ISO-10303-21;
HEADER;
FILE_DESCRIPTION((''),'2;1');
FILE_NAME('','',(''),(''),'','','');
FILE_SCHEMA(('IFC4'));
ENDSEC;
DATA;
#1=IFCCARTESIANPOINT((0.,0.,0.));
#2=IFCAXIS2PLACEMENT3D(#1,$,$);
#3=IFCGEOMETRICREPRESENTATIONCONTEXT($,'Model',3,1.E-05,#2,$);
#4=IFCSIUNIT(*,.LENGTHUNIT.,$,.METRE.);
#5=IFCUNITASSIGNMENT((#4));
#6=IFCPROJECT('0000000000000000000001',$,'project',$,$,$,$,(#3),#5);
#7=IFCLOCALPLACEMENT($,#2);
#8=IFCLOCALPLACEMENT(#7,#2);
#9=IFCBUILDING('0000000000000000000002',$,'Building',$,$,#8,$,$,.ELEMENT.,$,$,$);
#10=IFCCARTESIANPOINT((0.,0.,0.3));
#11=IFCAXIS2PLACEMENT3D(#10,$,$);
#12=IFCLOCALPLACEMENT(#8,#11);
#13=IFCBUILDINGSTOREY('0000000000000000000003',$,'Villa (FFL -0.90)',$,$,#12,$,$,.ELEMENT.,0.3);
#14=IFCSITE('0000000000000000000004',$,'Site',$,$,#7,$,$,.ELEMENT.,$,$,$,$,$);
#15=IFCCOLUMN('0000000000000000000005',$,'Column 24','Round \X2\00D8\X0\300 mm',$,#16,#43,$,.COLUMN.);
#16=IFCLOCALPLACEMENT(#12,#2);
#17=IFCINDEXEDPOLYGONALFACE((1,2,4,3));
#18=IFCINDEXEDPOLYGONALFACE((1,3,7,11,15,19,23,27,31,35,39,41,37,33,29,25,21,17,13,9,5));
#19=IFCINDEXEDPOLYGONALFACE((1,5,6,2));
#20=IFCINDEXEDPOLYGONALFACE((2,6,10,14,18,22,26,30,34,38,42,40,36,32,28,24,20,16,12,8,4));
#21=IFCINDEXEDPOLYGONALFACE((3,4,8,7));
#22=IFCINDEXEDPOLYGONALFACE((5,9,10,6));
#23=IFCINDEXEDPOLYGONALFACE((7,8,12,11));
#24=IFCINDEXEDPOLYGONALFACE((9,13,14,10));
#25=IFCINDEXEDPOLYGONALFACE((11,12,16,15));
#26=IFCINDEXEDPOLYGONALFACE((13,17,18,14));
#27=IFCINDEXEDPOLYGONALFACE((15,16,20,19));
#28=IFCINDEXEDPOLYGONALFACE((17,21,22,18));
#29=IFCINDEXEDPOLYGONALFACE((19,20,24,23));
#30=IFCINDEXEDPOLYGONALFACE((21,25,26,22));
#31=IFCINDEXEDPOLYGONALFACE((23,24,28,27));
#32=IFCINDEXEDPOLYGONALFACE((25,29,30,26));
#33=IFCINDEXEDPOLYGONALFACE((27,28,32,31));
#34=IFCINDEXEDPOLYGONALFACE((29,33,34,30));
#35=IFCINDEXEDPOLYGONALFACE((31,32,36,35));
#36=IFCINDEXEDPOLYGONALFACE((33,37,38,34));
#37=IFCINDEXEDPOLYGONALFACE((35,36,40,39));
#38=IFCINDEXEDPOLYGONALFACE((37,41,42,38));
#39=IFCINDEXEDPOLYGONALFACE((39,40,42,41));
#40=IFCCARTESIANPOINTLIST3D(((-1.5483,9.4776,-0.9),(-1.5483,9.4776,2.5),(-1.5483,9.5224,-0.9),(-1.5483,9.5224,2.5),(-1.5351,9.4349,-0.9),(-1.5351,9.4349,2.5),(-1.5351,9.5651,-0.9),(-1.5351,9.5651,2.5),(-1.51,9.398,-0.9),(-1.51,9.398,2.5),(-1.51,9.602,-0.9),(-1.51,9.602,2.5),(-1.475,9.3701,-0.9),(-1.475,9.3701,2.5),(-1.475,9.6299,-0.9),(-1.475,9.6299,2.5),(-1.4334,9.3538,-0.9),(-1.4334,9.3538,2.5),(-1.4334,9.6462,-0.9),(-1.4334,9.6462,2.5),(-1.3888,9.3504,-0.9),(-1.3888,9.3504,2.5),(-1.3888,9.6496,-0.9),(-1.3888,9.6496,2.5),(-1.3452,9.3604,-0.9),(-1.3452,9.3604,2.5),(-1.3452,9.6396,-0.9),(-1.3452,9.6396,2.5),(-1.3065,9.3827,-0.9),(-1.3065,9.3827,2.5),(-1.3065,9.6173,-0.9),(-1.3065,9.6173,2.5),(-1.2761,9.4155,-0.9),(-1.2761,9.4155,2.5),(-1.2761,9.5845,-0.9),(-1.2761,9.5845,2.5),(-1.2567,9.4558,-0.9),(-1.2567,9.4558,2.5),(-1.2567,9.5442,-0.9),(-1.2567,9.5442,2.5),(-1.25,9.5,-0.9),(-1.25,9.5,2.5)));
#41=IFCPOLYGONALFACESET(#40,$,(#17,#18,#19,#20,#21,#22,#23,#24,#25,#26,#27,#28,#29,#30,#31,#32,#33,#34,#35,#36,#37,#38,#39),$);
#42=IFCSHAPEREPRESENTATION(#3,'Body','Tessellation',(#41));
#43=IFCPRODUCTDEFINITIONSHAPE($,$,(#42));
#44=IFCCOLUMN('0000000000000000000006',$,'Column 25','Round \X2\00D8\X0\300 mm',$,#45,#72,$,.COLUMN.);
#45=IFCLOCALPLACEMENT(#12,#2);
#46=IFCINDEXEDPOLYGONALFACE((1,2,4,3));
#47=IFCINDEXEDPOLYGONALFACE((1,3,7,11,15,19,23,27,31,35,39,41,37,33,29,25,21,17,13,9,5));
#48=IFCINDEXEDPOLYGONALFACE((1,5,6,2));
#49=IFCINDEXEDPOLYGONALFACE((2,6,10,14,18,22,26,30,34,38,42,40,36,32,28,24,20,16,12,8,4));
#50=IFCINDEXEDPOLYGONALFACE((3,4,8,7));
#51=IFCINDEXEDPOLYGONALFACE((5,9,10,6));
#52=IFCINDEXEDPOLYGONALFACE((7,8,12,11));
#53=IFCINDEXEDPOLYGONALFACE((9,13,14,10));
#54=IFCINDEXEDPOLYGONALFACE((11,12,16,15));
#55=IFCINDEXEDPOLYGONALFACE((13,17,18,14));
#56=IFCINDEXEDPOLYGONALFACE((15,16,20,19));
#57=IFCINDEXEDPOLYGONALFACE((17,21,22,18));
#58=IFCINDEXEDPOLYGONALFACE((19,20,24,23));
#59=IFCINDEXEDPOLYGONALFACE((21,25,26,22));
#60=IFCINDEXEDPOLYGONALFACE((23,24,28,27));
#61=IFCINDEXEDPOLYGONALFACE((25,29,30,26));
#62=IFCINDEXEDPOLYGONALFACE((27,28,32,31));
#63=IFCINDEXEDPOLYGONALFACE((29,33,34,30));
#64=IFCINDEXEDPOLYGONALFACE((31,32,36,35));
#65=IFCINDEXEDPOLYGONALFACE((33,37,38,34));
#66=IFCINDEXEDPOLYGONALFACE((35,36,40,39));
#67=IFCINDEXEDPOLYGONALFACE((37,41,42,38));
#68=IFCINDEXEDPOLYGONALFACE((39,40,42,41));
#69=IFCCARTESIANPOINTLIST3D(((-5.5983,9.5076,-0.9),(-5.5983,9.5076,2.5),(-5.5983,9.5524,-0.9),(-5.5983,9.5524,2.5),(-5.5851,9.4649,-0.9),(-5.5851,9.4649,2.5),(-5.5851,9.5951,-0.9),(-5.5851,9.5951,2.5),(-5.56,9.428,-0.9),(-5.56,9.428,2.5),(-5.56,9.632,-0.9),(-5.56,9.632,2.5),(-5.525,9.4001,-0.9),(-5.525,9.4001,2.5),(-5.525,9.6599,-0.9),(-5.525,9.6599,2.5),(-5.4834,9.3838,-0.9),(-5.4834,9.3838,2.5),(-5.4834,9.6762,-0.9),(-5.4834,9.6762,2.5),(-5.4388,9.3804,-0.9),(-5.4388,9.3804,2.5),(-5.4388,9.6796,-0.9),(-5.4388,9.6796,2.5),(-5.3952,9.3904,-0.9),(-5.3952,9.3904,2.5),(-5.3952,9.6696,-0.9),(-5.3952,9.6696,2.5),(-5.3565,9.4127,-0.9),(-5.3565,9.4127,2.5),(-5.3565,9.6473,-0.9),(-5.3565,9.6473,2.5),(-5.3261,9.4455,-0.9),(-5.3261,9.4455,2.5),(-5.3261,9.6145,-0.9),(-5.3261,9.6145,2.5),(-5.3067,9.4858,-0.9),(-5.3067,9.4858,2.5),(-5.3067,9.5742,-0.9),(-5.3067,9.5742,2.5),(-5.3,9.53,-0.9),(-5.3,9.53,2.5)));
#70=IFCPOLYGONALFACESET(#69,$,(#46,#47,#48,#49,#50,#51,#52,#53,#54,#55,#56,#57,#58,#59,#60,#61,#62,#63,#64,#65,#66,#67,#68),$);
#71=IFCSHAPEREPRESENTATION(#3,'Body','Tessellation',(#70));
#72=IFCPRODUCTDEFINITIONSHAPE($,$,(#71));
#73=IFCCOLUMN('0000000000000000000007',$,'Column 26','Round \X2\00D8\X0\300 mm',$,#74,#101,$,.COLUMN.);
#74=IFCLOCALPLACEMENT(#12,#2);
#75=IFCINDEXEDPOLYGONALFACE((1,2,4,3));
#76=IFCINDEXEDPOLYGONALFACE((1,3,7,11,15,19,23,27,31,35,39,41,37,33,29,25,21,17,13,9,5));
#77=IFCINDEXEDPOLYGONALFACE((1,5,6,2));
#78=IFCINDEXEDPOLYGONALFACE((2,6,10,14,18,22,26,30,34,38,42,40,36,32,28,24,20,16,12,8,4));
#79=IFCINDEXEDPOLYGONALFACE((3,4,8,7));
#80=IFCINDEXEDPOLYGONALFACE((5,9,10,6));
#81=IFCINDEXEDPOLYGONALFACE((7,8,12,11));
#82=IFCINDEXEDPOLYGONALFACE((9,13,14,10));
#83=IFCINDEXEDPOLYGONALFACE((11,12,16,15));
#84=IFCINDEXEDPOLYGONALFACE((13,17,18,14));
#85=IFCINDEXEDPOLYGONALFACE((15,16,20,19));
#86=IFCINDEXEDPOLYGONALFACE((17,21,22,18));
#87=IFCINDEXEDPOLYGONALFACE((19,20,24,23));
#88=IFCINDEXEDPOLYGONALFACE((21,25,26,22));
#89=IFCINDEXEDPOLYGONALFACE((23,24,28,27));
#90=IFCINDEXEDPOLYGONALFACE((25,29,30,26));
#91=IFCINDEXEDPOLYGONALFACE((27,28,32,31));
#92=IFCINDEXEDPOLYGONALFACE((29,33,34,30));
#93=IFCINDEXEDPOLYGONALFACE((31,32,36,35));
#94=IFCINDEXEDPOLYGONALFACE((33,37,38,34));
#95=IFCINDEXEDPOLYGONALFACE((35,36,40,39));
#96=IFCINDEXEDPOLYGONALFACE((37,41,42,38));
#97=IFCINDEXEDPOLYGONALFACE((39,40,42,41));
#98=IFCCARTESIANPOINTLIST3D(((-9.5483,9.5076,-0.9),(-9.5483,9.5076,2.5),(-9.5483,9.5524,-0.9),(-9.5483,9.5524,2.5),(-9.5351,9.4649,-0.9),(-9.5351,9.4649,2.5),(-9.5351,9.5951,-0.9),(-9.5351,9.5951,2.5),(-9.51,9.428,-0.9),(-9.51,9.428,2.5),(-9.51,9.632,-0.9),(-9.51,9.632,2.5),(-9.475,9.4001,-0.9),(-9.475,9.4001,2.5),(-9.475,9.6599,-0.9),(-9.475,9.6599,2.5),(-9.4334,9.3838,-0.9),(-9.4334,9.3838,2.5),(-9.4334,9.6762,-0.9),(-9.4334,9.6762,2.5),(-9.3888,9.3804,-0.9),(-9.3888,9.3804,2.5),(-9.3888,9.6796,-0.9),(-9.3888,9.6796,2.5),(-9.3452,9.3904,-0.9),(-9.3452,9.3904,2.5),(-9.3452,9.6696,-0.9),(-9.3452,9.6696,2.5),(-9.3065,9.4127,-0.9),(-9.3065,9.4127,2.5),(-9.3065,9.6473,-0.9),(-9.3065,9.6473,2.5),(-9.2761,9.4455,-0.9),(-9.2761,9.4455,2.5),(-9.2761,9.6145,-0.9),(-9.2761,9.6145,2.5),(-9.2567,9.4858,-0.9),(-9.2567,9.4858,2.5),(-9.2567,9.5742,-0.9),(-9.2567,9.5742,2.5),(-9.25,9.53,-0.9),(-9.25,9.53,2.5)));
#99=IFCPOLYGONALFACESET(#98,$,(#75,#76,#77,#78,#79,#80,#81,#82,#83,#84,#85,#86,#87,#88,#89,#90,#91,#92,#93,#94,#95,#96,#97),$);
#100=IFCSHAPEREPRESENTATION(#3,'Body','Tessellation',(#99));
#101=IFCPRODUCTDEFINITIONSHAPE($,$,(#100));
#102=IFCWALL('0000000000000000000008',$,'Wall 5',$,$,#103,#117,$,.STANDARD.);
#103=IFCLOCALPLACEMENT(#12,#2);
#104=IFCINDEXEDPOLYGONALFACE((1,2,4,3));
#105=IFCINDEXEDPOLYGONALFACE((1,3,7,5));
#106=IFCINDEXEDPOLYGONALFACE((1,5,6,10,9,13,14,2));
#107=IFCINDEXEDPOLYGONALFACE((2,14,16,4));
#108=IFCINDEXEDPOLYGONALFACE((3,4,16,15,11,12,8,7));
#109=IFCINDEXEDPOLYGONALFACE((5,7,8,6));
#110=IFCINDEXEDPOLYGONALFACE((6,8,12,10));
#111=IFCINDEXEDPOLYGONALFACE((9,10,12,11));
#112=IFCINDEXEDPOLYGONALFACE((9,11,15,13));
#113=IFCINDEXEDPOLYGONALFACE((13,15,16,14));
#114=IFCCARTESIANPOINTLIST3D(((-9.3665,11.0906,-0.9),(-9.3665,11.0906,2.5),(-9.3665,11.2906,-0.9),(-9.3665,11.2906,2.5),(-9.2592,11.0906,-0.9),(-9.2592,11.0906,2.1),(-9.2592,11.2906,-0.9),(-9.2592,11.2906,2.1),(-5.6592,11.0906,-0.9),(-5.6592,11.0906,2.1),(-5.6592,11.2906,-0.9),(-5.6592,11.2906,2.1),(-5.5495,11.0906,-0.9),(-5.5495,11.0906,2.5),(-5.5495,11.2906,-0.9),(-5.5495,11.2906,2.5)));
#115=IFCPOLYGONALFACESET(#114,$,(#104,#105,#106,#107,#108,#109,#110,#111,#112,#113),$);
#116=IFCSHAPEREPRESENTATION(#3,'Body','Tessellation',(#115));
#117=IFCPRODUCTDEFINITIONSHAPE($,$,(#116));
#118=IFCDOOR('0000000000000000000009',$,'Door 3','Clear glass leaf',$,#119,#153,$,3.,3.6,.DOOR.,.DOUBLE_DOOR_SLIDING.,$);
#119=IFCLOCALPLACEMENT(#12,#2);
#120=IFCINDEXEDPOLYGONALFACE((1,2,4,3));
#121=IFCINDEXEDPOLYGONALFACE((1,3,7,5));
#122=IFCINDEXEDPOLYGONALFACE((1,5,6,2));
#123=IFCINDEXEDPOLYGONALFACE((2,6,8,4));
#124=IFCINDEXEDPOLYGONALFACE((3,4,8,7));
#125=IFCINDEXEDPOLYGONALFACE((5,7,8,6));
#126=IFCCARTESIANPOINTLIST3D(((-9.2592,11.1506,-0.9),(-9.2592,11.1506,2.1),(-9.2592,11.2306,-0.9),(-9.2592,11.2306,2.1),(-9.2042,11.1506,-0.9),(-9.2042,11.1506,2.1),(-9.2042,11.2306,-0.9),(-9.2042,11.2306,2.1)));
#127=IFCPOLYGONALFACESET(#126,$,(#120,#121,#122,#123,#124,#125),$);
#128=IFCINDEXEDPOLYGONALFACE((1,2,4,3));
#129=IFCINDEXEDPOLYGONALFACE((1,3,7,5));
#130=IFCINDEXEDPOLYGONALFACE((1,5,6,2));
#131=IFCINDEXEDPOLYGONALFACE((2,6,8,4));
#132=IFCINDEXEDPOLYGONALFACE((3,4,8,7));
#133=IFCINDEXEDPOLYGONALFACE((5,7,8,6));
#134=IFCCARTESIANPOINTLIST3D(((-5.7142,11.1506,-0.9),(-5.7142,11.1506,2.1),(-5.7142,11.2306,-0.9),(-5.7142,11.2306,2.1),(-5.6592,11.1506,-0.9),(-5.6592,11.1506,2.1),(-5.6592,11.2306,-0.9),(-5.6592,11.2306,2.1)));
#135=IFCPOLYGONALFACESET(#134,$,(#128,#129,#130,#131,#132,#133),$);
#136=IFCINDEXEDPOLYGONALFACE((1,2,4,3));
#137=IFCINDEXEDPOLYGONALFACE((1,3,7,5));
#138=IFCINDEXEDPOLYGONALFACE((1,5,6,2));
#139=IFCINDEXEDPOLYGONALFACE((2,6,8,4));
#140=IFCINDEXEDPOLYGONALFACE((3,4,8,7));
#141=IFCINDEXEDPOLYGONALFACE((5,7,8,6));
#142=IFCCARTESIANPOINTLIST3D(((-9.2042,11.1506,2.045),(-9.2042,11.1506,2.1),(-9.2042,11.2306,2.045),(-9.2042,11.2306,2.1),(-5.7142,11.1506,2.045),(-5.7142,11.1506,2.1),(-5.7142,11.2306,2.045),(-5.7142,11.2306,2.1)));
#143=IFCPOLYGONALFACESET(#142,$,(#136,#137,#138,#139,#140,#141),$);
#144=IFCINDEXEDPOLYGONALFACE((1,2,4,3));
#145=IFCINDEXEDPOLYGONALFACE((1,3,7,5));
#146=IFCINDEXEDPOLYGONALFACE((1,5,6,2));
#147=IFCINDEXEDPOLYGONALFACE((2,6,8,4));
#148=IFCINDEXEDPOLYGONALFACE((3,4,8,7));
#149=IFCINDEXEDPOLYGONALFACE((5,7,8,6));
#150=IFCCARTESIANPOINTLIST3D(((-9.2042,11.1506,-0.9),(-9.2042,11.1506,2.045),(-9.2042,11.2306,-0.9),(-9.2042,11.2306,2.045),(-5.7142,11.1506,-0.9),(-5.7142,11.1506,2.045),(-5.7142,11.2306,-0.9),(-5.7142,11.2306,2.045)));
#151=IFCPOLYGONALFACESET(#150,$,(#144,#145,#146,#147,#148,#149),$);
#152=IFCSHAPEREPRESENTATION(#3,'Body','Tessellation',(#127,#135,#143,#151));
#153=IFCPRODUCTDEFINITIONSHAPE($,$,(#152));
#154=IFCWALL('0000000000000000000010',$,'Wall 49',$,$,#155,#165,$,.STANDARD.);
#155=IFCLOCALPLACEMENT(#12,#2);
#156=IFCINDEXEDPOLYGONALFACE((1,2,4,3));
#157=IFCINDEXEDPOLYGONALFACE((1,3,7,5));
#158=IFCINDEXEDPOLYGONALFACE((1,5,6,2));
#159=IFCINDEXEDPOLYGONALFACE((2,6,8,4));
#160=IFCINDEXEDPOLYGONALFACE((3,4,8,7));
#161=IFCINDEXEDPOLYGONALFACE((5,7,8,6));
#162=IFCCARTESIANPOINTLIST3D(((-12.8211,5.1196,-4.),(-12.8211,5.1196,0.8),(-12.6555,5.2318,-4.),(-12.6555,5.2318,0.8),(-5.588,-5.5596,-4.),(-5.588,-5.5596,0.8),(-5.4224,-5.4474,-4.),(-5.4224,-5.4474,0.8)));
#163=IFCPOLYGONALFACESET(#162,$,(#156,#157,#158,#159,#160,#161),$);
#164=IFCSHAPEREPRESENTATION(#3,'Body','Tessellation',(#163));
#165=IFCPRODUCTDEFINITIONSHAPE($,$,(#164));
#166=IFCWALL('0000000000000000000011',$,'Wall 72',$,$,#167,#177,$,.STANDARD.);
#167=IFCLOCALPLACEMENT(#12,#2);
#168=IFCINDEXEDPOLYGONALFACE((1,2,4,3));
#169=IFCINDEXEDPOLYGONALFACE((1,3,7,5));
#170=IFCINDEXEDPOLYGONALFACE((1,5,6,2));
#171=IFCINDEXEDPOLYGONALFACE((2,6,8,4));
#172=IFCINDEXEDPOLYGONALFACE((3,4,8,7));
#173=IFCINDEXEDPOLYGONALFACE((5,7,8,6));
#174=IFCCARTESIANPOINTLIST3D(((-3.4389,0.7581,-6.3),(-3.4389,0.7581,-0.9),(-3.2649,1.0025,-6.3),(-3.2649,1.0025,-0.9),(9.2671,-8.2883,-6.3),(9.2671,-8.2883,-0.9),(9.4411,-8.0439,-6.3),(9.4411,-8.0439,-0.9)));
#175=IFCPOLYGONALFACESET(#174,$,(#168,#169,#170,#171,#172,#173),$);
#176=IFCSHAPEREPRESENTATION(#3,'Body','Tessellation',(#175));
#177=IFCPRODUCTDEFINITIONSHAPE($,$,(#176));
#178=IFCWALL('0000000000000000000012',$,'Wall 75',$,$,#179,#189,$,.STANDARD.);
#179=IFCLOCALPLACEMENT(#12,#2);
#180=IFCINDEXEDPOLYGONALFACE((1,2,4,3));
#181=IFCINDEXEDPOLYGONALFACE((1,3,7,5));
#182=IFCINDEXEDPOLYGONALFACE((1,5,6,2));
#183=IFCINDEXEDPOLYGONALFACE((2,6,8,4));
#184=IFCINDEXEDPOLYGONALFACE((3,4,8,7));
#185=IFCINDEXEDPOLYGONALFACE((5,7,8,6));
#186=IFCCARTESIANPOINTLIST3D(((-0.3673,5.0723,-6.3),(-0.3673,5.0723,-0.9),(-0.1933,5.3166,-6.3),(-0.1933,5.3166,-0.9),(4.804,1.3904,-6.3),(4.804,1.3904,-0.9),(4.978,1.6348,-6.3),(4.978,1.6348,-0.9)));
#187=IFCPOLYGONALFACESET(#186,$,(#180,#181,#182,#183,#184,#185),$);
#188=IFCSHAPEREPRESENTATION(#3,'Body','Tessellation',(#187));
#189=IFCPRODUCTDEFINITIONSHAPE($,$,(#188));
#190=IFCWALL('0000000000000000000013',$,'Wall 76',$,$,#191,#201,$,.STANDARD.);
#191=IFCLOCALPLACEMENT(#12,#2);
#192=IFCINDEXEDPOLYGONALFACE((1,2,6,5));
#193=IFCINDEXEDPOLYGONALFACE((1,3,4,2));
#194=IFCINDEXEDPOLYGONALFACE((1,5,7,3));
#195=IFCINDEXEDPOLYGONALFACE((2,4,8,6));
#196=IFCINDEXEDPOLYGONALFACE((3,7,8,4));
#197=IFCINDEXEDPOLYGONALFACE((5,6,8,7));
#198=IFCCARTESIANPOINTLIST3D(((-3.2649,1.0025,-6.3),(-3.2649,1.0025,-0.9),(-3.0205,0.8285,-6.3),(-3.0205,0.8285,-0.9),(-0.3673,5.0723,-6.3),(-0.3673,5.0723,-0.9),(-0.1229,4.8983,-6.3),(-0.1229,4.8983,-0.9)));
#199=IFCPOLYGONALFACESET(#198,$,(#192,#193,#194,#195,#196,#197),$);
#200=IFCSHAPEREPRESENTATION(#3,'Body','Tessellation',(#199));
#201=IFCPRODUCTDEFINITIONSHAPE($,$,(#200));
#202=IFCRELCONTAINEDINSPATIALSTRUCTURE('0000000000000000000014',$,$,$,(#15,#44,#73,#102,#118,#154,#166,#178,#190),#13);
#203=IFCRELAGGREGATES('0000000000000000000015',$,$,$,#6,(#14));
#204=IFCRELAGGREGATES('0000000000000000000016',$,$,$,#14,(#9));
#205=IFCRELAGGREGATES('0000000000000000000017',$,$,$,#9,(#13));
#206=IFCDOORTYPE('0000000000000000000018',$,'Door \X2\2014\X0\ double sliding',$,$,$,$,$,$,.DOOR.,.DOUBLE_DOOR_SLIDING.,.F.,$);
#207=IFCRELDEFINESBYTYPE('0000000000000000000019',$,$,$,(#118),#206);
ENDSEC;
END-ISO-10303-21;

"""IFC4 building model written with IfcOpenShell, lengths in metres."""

from ifc_helpers import new_model, si_unit, frame, frame_2d, origin, origin_2d, place, context, project, spatial, rectangle, circle, extrude, type_object, element, fill, save


model = new_model("IFC4")

# Units and contexts
model_context = context("Model", 3, precision=1e-05, world=origin())
ifc_project = project(units=[si_unit("LENGTHUNIT", "METRE")], contexts=[model_context])

# Site, building, storey
site_placement = place(None, origin())
site = spatial("IfcSite", under=ifc_project, at=site_placement, Name="Site", CompositionType="ELEMENT")
building_placement = place(site_placement, origin())
building = spatial("IfcBuilding", under=site, at=building_placement, Name="Building", CompositionType="ELEMENT")
storey_placement = place(building_placement, frame((0.0, 0.0, 0.3)))
storey = spatial("IfcBuildingStorey", under=building, at=storey_placement, Name="Villa (FFL -0.90)", CompositionType="ELEMENT", Elevation=0.3)

# Columns
for number, where, z_axis, x_axis, name in (
    (1, (-1.4, 9.5, -0.9), (0.0, 0.0, 1.0), (1.0, 0.0, 0.0), "Column 24"),
    (2, (-5.45, 9.53, -0.9), (0.0, 0.0, 1.0), (1.0, 0.0, 0.0), "Column 25"),
    (3, (-9.4, 9.53, -0.9), (0.0, 0.0, 1.0), (1.0, 0.0, 0.0), "Column 26"),
):
    element("IfcColumn", number, at=place(storey_placement, frame(where, z_axis=z_axis, x_axis=x_axis)), inside=storey, Name=name, Description="Round Ø300 mm", PredefinedType="COLUMN", context=model_context, shape_type="SweptSolid", body=[
        extrude(circle(Radius=0.15, at=origin_2d()), origin(), (0.0, 0.0, 1.0), 3.4),
    ])

# Wall, opening, door
wall_1_placement = place(storey_placement, frame((-9.3665, 11.1906, -0.9), z_axis=(0.0, 0.0, 1.0), x_axis=(1.0, 0.0, 0.0)))
wall_1 = element("IfcWall", 4, at=wall_1_placement, inside=storey, Name="Wall 5", PredefinedType="STANDARD", context=model_context, shape_type="SweptSolid", body=[
    extrude(rectangle(XDim=3.817, YDim=0.2, at=frame_2d((1.9085, 0.0))), origin(), (0.0, 0.0, 1.0), 3.4),
])
opening_placement = place(storey_placement, frame((-9.2592, 11.1906, -0.9), z_axis=(0.0, 0.0, 1.0), x_axis=(1.0, 0.0, 0.0)))
opening = element("IfcOpeningElement", 5, at=opening_placement, cuts=wall_1, PredefinedType="OPENING", context=model_context, shape_type="SweptSolid", body=[
    extrude(rectangle(XDim=3.6, YDim=0.26, at=frame_2d((1.8, 0.0))), origin(), (0.0, 0.0, 1.0), 3.0),
])
door_type = type_object("IfcDoorType", Name="Door — double sliding", OperationType="DOUBLE_DOOR_SLIDING", ParameterTakesPrecedence=False, PredefinedType="DOOR")
door_placement = place(storey_placement, frame((-9.2592, 11.1906, -0.9), z_axis=(0.0, 0.0, 1.0), x_axis=(1.0, 0.0, 0.0)))
door = element("IfcDoor", 6, at=door_placement, inside=storey, type_object=door_type, Name="Door 3", Description="Clear glass leaf", OperationType="DOUBLE_DOOR_SLIDING", OverallHeight=3.0, OverallWidth=3.6, PredefinedType="DOOR", context=model_context, shape_type="SweptSolid", body=[
    extrude(rectangle(XDim=0.055, YDim=0.08, at=frame_2d((0.0275, 0.0))), origin(), (0.0, 0.0, 1.0), 3.0),
    extrude(rectangle(XDim=0.055, YDim=0.08, at=frame_2d((3.5725, 0.0))), origin(), (0.0, 0.0, 1.0), 3.0),
    extrude(rectangle(XDim=3.49, YDim=0.08, at=frame_2d((1.8, 0.0))), frame((0.0, 0.0, 2.945)), (0.0, 0.0, 1.0), 0.055),
    extrude(rectangle(XDim=3.49, YDim=0.08, at=frame_2d((1.8, 0.0))), origin(), (0.0, 0.0, 1.0), 2.945),
])
fill(opening, door)

# Walls
wall_2_placement = place(storey_placement, frame((-12.7383, 5.1757, -4.0), z_axis=(0.0, 0.0, 1.0), x_axis=(0.560785, -0.827962, 0.0)))
element("IfcWall", 7, at=wall_2_placement, inside=storey, Name="Wall 49", PredefinedType="STANDARD", context=model_context, shape_type="SweptSolid", body=[
    extrude(rectangle(XDim=12.8982, YDim=0.2, at=frame_2d((6.4491, 0.0))), origin(), (0.0, 0.0, 1.0), 4.8),
])
wall_3_placement = place(storey_placement, frame((-3.3519, 0.8803, -6.3), z_axis=(0.0, 0.0, 1.0), x_axis=(0.814622, -0.579992, 0.0)))
element("IfcWall", 8, at=wall_3_placement, inside=storey, Name="Wall 72", PredefinedType="STANDARD", context=model_context, shape_type="SweptSolid", body=[
    extrude(rectangle(XDim=15.5974, YDim=0.3, at=frame_2d((7.7987, 0.0))), origin(), (0.0, 0.0, 1.0), 5.4),
])
wall_4_placement = place(storey_placement, frame((-0.2803, 5.1945, -6.3), z_axis=(0.0, 0.0, 1.0), x_axis=(0.814622, -0.579992, 0.0)))
element("IfcWall", 9, at=wall_4_placement, inside=storey, Name="Wall 75", PredefinedType="STANDARD", context=model_context, shape_type="SweptSolid", body=[
    extrude(rectangle(XDim=6.348, YDim=0.3, at=frame_2d((3.174, 0.0))), origin(), (0.0, 0.0, 1.0), 5.4),
])
wall_5_placement = place(storey_placement, frame((-3.1427, 0.9155, -6.3), z_axis=(0.0, 0.0, 1.0), x_axis=(0.579992, 0.814622, 0.0)))
element("IfcWall", 10, at=wall_5_placement, inside=storey, Name="Wall 76", PredefinedType="STANDARD", context=model_context, shape_type="SweptSolid", body=[
    extrude(rectangle(XDim=4.9959, YDim=0.3, at=frame_2d((2.498, 0.0))), origin(), (0.0, 0.0, 1.0), 5.4),
])

save(model, "model.ifc")
